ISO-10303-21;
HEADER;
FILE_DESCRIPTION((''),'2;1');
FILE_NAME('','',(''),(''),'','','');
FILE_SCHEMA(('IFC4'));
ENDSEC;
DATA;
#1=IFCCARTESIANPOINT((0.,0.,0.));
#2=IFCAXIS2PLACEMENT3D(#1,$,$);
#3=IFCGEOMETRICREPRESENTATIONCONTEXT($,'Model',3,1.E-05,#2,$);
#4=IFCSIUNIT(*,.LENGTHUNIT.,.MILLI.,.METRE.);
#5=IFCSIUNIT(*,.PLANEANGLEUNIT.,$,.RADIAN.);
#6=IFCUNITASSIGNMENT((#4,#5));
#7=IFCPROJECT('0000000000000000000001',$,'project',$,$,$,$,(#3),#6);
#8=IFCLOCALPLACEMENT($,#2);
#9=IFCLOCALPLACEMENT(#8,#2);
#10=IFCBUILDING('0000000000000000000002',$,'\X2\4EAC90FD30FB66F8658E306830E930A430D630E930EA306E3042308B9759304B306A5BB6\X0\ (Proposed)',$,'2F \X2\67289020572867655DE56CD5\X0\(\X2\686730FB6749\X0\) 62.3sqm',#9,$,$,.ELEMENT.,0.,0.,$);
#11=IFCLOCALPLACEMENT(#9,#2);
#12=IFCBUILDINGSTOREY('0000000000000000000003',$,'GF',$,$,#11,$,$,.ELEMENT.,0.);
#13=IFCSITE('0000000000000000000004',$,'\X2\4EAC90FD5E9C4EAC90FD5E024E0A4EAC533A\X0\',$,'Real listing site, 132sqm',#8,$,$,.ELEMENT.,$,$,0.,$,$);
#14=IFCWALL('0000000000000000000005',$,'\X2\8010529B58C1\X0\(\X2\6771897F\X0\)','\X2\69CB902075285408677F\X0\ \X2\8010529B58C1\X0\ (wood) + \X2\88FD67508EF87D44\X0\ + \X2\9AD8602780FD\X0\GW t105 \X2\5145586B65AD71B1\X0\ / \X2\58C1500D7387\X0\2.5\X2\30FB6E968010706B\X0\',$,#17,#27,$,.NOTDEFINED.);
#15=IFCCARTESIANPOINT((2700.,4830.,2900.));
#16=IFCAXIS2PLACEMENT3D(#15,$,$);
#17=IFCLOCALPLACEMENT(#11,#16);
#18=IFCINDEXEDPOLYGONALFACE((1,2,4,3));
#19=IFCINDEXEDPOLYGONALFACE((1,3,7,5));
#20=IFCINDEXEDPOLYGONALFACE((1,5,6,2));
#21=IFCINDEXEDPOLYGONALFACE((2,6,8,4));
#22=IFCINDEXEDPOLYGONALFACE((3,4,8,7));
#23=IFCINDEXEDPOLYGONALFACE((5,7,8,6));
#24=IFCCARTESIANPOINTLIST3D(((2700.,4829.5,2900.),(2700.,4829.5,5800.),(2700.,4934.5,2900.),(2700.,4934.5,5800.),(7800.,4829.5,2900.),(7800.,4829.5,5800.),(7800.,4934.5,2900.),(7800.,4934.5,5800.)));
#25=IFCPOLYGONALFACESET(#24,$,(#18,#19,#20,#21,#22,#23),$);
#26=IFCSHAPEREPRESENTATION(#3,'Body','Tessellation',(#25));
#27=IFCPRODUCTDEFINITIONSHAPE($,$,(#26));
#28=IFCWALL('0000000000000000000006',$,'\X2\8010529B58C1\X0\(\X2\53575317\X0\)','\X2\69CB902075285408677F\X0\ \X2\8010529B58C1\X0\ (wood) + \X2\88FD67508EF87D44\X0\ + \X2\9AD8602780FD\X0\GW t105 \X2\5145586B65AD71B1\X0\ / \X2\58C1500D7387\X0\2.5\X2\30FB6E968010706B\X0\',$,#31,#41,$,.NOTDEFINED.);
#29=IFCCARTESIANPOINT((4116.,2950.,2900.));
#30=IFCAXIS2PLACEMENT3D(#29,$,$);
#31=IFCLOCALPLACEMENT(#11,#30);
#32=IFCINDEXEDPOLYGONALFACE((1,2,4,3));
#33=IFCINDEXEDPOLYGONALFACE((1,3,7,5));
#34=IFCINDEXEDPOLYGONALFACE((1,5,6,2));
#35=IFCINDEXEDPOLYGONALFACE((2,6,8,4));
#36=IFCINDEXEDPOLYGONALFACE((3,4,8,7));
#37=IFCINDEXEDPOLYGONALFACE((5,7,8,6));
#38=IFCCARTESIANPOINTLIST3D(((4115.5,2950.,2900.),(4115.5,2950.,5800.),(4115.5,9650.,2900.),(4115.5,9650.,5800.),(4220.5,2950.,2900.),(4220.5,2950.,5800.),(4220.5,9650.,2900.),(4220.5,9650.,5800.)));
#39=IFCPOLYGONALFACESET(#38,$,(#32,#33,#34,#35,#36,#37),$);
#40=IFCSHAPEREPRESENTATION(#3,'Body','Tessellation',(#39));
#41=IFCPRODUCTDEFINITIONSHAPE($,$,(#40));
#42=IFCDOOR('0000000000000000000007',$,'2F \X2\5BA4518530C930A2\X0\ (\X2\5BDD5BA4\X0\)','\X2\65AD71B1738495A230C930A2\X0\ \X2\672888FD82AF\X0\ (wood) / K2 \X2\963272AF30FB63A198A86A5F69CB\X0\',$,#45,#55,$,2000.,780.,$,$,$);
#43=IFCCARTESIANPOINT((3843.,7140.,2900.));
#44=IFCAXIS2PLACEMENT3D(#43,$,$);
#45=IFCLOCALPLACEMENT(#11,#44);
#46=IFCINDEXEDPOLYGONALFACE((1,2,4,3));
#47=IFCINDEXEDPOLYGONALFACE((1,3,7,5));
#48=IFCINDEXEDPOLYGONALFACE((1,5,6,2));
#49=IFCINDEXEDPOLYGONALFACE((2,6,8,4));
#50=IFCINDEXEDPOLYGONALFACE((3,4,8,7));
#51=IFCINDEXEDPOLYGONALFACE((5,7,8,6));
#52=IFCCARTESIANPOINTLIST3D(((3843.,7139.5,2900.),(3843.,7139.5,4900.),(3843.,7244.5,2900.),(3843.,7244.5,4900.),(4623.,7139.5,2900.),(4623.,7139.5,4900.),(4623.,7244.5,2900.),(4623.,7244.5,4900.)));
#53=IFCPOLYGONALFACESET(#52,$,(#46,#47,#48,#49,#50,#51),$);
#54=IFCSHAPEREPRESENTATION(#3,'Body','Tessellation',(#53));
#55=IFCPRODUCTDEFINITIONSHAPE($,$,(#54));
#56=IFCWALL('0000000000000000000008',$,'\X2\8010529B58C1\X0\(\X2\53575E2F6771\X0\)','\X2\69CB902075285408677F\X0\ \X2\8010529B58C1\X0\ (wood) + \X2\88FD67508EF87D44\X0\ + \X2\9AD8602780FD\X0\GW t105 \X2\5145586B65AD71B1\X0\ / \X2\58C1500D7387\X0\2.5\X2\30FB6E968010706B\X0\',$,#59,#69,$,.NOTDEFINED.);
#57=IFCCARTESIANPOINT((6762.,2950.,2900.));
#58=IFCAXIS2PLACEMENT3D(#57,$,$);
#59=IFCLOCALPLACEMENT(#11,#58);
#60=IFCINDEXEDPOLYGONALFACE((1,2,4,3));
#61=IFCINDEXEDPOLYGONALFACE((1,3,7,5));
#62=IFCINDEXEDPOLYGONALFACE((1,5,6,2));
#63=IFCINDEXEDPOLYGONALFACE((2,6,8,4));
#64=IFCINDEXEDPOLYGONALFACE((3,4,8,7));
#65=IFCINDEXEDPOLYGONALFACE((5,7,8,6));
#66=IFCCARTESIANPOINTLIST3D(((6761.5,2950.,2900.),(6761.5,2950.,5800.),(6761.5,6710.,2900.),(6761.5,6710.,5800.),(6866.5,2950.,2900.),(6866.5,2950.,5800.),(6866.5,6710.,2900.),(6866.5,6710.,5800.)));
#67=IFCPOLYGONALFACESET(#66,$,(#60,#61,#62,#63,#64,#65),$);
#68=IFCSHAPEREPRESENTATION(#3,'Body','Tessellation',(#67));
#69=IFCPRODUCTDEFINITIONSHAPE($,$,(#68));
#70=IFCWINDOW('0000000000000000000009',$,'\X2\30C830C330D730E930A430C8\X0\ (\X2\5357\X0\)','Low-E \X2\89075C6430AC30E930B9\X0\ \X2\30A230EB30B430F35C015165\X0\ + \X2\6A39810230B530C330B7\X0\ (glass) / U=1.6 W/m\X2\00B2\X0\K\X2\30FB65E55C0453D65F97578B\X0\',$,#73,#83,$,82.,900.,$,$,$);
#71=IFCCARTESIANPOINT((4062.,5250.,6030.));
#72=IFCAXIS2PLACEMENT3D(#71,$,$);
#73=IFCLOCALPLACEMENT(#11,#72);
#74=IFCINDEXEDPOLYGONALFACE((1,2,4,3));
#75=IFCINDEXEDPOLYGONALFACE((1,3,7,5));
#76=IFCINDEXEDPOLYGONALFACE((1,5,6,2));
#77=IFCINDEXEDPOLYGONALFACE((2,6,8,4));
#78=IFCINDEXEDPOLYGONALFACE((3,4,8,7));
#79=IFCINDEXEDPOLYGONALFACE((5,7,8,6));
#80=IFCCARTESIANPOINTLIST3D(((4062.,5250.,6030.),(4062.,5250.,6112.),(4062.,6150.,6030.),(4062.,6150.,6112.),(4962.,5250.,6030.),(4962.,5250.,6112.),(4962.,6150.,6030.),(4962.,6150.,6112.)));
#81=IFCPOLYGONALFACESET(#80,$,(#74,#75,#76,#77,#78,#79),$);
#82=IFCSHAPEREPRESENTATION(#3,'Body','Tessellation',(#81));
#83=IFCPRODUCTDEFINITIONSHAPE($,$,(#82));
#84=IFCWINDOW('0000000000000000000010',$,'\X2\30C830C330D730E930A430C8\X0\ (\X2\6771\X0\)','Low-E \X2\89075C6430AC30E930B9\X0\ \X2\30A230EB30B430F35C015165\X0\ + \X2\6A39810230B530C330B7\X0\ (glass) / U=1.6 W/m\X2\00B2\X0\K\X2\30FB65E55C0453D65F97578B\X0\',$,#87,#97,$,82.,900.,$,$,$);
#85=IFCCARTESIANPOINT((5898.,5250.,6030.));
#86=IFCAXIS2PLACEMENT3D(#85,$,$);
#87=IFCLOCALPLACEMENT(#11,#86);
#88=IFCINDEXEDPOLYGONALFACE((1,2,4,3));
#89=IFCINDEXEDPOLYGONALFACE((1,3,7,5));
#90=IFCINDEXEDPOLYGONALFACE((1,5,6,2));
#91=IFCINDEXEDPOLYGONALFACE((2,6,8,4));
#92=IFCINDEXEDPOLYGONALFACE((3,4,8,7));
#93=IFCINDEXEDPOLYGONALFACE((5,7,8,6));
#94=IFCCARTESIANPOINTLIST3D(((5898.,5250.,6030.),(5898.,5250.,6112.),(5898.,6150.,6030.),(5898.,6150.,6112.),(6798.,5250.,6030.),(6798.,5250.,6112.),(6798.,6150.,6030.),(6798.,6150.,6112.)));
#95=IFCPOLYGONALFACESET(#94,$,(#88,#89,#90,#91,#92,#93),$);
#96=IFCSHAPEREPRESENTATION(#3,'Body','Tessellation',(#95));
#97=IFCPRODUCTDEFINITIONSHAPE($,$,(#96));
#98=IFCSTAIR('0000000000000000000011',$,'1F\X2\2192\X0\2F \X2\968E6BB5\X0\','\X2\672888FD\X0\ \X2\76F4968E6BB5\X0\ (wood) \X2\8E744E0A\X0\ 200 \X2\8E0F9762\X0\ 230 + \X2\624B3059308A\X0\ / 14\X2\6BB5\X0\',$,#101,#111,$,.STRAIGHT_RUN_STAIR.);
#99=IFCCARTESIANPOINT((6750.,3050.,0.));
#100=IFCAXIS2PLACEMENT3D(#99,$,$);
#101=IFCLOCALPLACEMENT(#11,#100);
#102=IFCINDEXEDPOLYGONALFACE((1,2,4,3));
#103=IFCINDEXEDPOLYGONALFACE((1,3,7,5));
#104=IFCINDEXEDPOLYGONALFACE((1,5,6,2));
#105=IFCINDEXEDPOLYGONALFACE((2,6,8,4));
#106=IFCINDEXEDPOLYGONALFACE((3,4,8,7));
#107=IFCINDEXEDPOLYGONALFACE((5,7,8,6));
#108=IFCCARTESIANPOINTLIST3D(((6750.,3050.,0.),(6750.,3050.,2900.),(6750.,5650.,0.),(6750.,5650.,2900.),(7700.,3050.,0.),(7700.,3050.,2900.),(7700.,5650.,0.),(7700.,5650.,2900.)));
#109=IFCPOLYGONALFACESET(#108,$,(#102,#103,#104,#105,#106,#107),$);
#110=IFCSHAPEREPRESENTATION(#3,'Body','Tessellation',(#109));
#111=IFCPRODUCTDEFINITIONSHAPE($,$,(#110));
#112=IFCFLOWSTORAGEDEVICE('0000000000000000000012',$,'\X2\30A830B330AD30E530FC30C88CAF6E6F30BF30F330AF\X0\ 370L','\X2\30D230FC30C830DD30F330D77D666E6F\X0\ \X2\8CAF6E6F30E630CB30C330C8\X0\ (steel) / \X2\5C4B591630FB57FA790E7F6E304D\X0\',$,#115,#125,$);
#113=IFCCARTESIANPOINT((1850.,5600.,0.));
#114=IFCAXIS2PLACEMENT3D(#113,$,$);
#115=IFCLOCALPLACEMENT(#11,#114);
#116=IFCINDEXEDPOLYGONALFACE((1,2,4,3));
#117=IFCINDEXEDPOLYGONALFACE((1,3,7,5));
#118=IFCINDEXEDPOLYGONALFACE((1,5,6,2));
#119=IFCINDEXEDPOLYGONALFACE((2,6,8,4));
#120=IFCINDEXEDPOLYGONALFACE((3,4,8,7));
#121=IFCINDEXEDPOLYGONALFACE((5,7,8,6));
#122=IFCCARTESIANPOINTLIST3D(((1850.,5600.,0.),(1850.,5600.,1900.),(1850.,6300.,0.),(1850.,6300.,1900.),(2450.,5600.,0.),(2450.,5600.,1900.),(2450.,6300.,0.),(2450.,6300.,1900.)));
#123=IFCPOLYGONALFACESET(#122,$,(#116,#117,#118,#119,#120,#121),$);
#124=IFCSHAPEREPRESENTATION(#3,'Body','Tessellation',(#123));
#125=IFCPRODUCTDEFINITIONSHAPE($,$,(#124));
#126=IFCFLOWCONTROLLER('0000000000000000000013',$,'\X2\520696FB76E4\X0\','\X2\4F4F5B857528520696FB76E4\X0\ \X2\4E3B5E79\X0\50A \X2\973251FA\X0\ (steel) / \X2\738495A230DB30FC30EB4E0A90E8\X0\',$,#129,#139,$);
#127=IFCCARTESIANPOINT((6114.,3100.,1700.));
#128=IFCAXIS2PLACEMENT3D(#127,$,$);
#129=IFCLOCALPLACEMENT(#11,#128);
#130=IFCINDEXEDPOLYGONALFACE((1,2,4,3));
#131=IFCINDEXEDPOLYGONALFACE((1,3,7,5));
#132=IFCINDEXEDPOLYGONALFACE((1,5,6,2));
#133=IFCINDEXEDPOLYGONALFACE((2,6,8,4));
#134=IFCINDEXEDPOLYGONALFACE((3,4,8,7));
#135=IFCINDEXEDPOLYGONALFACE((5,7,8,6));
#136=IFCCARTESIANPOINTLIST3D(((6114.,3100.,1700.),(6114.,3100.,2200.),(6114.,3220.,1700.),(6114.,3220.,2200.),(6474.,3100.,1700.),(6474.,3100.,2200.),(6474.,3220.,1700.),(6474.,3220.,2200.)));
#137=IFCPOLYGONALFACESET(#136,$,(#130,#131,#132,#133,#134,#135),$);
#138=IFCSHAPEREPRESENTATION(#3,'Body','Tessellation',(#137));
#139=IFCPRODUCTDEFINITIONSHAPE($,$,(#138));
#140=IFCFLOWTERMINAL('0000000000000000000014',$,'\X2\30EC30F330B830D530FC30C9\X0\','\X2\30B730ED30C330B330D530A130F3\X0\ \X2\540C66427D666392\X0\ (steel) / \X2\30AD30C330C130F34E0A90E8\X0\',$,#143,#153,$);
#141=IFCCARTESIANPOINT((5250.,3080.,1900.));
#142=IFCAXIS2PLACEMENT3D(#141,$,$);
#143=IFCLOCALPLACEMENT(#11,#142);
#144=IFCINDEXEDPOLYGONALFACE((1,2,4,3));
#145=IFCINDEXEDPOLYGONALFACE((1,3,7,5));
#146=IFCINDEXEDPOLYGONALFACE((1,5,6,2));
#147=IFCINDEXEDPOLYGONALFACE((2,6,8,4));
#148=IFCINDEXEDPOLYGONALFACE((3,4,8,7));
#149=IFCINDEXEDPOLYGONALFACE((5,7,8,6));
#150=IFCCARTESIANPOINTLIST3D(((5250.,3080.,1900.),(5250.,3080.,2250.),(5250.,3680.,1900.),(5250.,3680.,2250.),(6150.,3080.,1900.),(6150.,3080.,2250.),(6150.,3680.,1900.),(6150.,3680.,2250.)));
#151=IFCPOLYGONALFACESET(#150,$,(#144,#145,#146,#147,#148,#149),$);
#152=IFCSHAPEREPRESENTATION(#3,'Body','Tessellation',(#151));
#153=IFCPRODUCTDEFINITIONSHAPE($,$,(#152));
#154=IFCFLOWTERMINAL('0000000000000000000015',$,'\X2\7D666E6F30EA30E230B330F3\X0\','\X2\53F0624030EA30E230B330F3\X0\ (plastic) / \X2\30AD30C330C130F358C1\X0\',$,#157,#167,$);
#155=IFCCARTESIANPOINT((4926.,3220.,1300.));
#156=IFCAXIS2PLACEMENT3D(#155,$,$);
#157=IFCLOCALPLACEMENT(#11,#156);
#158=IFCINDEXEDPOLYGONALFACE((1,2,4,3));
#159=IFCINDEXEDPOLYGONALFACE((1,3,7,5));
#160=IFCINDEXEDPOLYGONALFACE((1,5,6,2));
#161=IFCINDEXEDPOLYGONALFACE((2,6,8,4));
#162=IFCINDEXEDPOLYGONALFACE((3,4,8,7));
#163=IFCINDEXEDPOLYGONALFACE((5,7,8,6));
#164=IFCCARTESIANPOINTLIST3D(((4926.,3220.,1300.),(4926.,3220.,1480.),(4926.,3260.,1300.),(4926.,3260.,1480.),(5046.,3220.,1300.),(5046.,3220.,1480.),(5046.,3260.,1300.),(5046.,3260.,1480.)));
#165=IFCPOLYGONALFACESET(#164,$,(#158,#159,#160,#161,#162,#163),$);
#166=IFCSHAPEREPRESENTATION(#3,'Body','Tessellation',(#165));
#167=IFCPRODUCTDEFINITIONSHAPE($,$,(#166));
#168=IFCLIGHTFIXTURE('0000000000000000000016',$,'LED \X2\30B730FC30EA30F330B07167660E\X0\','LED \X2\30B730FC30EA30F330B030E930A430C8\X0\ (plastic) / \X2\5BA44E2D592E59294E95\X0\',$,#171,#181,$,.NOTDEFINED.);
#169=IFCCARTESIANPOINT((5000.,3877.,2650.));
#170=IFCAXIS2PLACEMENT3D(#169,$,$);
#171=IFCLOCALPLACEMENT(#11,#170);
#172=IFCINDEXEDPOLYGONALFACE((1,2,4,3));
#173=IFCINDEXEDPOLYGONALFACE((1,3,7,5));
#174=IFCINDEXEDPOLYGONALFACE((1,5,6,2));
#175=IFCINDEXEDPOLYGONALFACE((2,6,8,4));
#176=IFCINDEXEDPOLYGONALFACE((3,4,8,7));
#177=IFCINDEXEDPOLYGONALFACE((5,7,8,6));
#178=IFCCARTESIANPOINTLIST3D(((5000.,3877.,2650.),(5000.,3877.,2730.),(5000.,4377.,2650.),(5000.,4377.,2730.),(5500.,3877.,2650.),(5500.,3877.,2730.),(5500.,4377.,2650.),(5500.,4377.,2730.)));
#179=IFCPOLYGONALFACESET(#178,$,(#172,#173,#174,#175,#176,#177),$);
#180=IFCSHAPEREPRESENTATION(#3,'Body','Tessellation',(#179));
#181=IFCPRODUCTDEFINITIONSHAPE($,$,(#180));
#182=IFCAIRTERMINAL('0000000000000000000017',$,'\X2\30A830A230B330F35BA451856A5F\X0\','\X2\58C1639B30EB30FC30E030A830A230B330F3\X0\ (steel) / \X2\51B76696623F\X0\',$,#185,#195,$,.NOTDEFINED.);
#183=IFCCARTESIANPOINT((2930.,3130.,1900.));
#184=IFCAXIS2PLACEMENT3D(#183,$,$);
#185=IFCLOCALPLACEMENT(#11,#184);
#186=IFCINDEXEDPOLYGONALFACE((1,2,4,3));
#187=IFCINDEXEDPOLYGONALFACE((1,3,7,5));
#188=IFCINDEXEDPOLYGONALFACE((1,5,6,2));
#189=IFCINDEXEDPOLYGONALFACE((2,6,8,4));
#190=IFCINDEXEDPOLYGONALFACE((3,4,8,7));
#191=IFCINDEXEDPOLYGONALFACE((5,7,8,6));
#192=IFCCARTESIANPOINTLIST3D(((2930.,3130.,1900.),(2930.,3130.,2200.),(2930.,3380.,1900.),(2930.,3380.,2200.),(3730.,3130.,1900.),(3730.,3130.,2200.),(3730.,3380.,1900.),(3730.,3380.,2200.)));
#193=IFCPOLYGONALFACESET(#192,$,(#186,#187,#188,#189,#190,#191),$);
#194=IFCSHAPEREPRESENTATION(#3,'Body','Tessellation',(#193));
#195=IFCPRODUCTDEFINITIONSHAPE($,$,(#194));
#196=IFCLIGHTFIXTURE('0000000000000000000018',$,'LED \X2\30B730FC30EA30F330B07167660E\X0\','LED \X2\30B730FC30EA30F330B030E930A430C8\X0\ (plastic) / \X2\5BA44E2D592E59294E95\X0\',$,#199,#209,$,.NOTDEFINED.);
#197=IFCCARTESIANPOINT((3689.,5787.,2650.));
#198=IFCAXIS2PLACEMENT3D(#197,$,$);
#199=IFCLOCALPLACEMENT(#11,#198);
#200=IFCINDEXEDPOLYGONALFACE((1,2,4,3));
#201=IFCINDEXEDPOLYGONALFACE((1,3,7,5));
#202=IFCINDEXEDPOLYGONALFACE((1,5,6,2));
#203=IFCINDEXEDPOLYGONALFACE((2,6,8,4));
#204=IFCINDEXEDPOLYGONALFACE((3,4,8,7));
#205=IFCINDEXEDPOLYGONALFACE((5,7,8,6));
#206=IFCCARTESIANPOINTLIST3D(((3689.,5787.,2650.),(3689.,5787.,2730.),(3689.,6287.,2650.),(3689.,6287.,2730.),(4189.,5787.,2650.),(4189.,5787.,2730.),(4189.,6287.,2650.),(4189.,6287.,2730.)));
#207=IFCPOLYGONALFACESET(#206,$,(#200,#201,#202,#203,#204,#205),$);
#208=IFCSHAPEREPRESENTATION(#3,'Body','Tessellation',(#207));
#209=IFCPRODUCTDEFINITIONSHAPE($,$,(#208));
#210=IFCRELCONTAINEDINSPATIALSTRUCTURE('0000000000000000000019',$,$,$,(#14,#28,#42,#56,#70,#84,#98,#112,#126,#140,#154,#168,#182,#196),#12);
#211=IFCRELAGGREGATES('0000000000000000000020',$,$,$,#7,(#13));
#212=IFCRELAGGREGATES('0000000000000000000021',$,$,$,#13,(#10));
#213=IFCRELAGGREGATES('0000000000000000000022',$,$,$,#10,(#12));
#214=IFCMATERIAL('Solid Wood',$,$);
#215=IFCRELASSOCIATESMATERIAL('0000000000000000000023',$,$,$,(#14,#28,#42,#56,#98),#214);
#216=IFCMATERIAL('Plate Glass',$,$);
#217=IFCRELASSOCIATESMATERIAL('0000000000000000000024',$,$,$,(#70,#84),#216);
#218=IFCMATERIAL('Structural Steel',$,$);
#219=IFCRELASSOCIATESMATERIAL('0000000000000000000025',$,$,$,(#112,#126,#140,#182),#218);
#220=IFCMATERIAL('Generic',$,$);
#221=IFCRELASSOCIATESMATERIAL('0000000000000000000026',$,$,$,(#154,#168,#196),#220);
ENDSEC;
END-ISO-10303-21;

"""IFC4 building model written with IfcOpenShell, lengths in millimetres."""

from ifc_helpers import new_model, si_unit, frame, frame_2d, origin, place, context, project, spatial, rectangle, extrude, material, element, fill, save


model = new_model("IFC4")

# Units and contexts
model_context = context("Model", 3, precision=1e-05, world=origin())
ifc_project = project(units=[si_unit("LENGTHUNIT", "METRE", prefix="MILLI"), si_unit("PLANEANGLEUNIT", "RADIAN")], contexts=[model_context])

# Site, building, storey
site_placement = place(None, origin())
site = spatial("IfcSite", under=ifc_project, at=site_placement, Name="京都府京都市上京区", ObjectType="Real listing site, 132sqm", CompositionType="ELEMENT", RefElevation=0.0)
building_placement = place(site_placement, origin())
building = spatial("IfcBuilding", under=site, at=building_placement, Name="京都・書斎とライブラリのある静かな家 (Proposed)", ObjectType="2F 木造在来工法(桧・杉) 62.3sqm", CompositionType="ELEMENT", ElevationOfRefHeight=0.0, ElevationOfTerrain=0.0)
storey_placement = place(building_placement, origin())
storey = spatial("IfcBuildingStorey", under=building, at=storey_placement, Name="GF", CompositionType="ELEMENT", Elevation=0.0)

# Shared definitions
ifc_material_1 = material(Name="Solid Wood")

# Wall
wall_1_placement = place(storey_placement, frame((2700.0, 4830.0, 2900.0)))
element("IfcWall", 1, at=wall_1_placement, inside=storey, material=ifc_material_1, Name="耐力壁(東西)", Description="構造用合板 耐力壁 (wood) + 製材軸組 + 高性能GW t105 充填断熱 / 壁倍率2.5・準耐火", PredefinedType="NOTDEFINED", context=model_context, shape_type="SweptSolid", body=[
    extrude(rectangle(XDim=5100.0, YDim=105.0, at=frame_2d((2550.0, 52.0))), frame((2700.0, 4830.0, 2900.0)), (0.0, 0.0, 1.0), 2900.0),
])

# Wall, opening, door
wall_2_placement = place(storey_placement, frame((4116.0, 2950.0, 2900.0)))
wall_2 = element("IfcWall", 2, at=wall_2_placement, inside=storey, material=ifc_material_1, Name="耐力壁(南北)", Description="構造用合板 耐力壁 (wood) + 製材軸組 + 高性能GW t105 充填断熱 / 壁倍率2.5・準耐火", PredefinedType="NOTDEFINED", context=model_context, shape_type="SweptSolid", body=[
    extrude(rectangle(XDim=105.0, YDim=6700.0, at=frame_2d((52.0, 3350.0))), frame((4116.0, 2950.0, 2900.0)), (0.0, 0.0, 1.0), 2900.0),
])
opening_placement = place(storey_placement, frame((3843.0, 7140.0, 2900.0)))
opening = element("IfcOpeningElement", 3, at=opening_placement, cuts=wall_2, PredefinedType="NOTDEFINED", context=model_context, shape_type="SweptSolid", body=[
    extrude(rectangle(XDim=780.0, YDim=105.0, at=frame_2d((390.0, 52.0))), frame((3843.0, 7140.0, 2900.0)), (0.0, 0.0, 1.0), 2000.0),
])
door_placement = place(storey_placement, frame((3843.0, 7140.0, 2900.0)))
door = element("IfcDoor", 4, at=door_placement, inside=storey, material=ifc_material_1, Name="2F 室内ドア (寝室)", Description="断熱玄関ドア 木製芯 (wood) / K2 防犯・採風機構", OverallHeight=2000.0, OverallWidth=780.0, context=model_context, shape_type="SweptSolid", body=[
    extrude(rectangle(XDim=780.0, YDim=105.0, at=frame_2d((390.0, 52.0))), frame((3843.0, 7140.0, 2900.0)), (0.0, 0.0, 1.0), 2000.0),
])
fill(opening, door)

# Wall
wall_3_placement = place(storey_placement, frame((6762.0, 2950.0, 2900.0)))
element("IfcWall", 5, at=wall_3_placement, inside=storey, material=ifc_material_1, Name="耐力壁(南帯東)", Description="構造用合板 耐力壁 (wood) + 製材軸組 + 高性能GW t105 充填断熱 / 壁倍率2.5・準耐火", PredefinedType="NOTDEFINED", context=model_context, shape_type="SweptSolid", body=[
    extrude(rectangle(XDim=105.0, YDim=3760.0, at=frame_2d((52.0, 1880.0))), frame((6762.0, 2950.0, 2900.0)), (0.0, 0.0, 1.0), 2900.0),
])

# Windows
ifc_material_2 = material(Name="Plate Glass")
window_1_placement = place(storey_placement, frame((4062.0, 5250.0, 6030.0)))
element("IfcWindow", 6, at=window_1_placement, inside=storey, material=ifc_material_2, Name="トップライト (南)", Description="Low-E 複層ガラス アルゴン封入 + 樹脂サッシ (glass) / U=1.6 W/m²K・日射取得型", OverallHeight=82.0, OverallWidth=900.0, context=model_context, shape_type="SweptSolid", body=[
    extrude(rectangle(XDim=900.0, YDim=900.0, at=frame_2d((450.0, 450.0))), frame((4062.0, 5250.0, 6030.0)), (0.0, 0.0, 1.0), 82.0),
])
window_2_placement = place(storey_placement, frame((5898.0, 5250.0, 6030.0)))
element("IfcWindow", 7, at=window_2_placement, inside=storey, material=ifc_material_2, Name="トップライト (東)", Description="Low-E 複層ガラス アルゴン封入 + 樹脂サッシ (glass) / U=1.6 W/m²K・日射取得型", OverallHeight=82.0, OverallWidth=900.0, context=model_context, shape_type="SweptSolid", body=[
    extrude(rectangle(XDim=900.0, YDim=900.0, at=frame_2d((450.0, 450.0))), frame((5898.0, 5250.0, 6030.0)), (0.0, 0.0, 1.0), 82.0),
])

# Stair
stair_placement = place(storey_placement, frame((6750.0, 3050.0, 0.0)))
element("IfcStair", 8, at=stair_placement, inside=storey, material=ifc_material_1, Name="1F→2F 階段", Description="木製 直階段 (wood) 蹴上 200 踏面 230 + 手すり / 14段", PredefinedType="STRAIGHT_RUN_STAIR", context=model_context, shape_type="SweptSolid", body=[
    extrude(rectangle(XDim=950.0, YDim=2600.0, at=frame_2d((475.0, 1300.0))), frame((6750.0, 3050.0, 0.0)), (0.0, 0.0, 1.0), 2900.0),
])

# Flow storage device
ifc_material_3 = material(Name="Structural Steel")
flow_storage_device_placement = place(storey_placement, frame((1850.0, 5600.0, 0.0)))
element("IfcFlowStorageDevice", 9, at=flow_storage_device_placement, inside=storey, material=ifc_material_3, Name="エコキュート貯湯タンク 370L", Description="ヒートポンプ給湯 貯湯ユニット (steel) / 屋外・基礎置き", context=model_context, shape_type="SweptSolid", body=[
    extrude(rectangle(XDim=600.0, YDim=700.0, at=frame_2d((300.0, 350.0))), frame((1850.0, 5600.0, 0.0)), (0.0, 0.0, 1.0), 1900.0),
])

# Flow controller
flow_controller_placement = place(storey_placement, frame((6114.0, 3100.0, 1700.0)))
element("IfcFlowController", 10, at=flow_controller_placement, inside=storey, material=ifc_material_3, Name="分電盤", Description="住宅用分電盤 主幹50A 露出 (steel) / 玄関ホール上部", context=model_context, shape_type="SweptSolid", body=[
    extrude(rectangle(XDim=360.0, YDim=120.0, at=frame_2d((180.0, 60.0))), frame((6114.0, 3100.0, 1700.0)), (0.0, 0.0, 1.0), 500.0),
])

# Flow terminals
flow_terminal_1_placement = place(storey_placement, frame((5250.0, 3080.0, 1900.0)))
element("IfcFlowTerminal", 11, at=flow_terminal_1_placement, inside=storey, material=ifc_material_3, Name="レンジフード", Description="シロッコファン 同時給排 (steel) / キッチン上部", context=model_context, shape_type="SweptSolid", body=[
    extrude(rectangle(XDim=900.0, YDim=600.0, at=frame_2d((450.0, 300.0))), frame((5250.0, 3080.0, 1900.0)), (0.0, 0.0, 1.0), 350.0),
])
ifc_material_4 = material(Name="Generic")
flow_terminal_2_placement = place(storey_placement, frame((4926.0, 3220.0, 1300.0)))
element("IfcFlowTerminal", 12, at=flow_terminal_2_placement, inside=storey, material=ifc_material_4, Name="給湯リモコン", Description="台所リモコン (plastic) / キッチン壁", context=model_context, shape_type="SweptSolid", body=[
    extrude(rectangle(XDim=120.0, YDim=40.0, at=frame_2d((60.0, 20.0))), frame((4926.0, 3220.0, 1300.0)), (0.0, 0.0, 1.0), 180.0),
])

# Light fixture
light_fixture_1_placement = place(storey_placement, frame((5000.0, 3877.0, 2650.0)))
element("IfcLightFixture", 13, at=light_fixture_1_placement, inside=storey, material=ifc_material_4, Name="LED シーリング照明", Description="LED シーリングライト (plastic) / 室中央天井", PredefinedType="NOTDEFINED", context=model_context, shape_type="SweptSolid", body=[
    extrude(rectangle(XDim=500.0, YDim=500.0, at=frame_2d((250.0, 250.0))), frame((5000.0, 3877.0, 2650.0)), (0.0, 0.0, 1.0), 80.0),
])

# Air terminal
air_terminal_1_placement = place(storey_placement, frame((2930.0, 3130.0, 1900.0)))
element("IfcAirTerminal", 14, at=air_terminal_1_placement, inside=storey, material=ifc_material_3, Name="エアコン室内機", Description="壁掛ルームエアコン (steel) / 冷暖房", PredefinedType="NOTDEFINED", context=model_context, shape_type="SweptSolid", body=[
    extrude(rectangle(XDim=800.0, YDim=250.0, at=frame_2d((400.0, 125.0))), frame((2930.0, 3130.0, 1900.0)), (0.0, 0.0, 1.0), 300.0),
])

# Light fixture
light_fixture_2_placement = place(storey_placement, frame((3689.0, 5787.0, 2650.0)))
element("IfcLightFixture", 15, at=light_fixture_2_placement, inside=storey, material=ifc_material_4, Name="LED シーリング照明", Description="LED シーリングライト (plastic) / 室中央天井", PredefinedType="NOTDEFINED", context=model_context, shape_type="SweptSolid", body=[
    extrude(rectangle(XDim=500.0, YDim=500.0, at=frame_2d((250.0, 250.0))), frame((3689.0, 5787.0, 2650.0)), (0.0, 0.0, 1.0), 80.0),
])

save(model, "model.ifc")
